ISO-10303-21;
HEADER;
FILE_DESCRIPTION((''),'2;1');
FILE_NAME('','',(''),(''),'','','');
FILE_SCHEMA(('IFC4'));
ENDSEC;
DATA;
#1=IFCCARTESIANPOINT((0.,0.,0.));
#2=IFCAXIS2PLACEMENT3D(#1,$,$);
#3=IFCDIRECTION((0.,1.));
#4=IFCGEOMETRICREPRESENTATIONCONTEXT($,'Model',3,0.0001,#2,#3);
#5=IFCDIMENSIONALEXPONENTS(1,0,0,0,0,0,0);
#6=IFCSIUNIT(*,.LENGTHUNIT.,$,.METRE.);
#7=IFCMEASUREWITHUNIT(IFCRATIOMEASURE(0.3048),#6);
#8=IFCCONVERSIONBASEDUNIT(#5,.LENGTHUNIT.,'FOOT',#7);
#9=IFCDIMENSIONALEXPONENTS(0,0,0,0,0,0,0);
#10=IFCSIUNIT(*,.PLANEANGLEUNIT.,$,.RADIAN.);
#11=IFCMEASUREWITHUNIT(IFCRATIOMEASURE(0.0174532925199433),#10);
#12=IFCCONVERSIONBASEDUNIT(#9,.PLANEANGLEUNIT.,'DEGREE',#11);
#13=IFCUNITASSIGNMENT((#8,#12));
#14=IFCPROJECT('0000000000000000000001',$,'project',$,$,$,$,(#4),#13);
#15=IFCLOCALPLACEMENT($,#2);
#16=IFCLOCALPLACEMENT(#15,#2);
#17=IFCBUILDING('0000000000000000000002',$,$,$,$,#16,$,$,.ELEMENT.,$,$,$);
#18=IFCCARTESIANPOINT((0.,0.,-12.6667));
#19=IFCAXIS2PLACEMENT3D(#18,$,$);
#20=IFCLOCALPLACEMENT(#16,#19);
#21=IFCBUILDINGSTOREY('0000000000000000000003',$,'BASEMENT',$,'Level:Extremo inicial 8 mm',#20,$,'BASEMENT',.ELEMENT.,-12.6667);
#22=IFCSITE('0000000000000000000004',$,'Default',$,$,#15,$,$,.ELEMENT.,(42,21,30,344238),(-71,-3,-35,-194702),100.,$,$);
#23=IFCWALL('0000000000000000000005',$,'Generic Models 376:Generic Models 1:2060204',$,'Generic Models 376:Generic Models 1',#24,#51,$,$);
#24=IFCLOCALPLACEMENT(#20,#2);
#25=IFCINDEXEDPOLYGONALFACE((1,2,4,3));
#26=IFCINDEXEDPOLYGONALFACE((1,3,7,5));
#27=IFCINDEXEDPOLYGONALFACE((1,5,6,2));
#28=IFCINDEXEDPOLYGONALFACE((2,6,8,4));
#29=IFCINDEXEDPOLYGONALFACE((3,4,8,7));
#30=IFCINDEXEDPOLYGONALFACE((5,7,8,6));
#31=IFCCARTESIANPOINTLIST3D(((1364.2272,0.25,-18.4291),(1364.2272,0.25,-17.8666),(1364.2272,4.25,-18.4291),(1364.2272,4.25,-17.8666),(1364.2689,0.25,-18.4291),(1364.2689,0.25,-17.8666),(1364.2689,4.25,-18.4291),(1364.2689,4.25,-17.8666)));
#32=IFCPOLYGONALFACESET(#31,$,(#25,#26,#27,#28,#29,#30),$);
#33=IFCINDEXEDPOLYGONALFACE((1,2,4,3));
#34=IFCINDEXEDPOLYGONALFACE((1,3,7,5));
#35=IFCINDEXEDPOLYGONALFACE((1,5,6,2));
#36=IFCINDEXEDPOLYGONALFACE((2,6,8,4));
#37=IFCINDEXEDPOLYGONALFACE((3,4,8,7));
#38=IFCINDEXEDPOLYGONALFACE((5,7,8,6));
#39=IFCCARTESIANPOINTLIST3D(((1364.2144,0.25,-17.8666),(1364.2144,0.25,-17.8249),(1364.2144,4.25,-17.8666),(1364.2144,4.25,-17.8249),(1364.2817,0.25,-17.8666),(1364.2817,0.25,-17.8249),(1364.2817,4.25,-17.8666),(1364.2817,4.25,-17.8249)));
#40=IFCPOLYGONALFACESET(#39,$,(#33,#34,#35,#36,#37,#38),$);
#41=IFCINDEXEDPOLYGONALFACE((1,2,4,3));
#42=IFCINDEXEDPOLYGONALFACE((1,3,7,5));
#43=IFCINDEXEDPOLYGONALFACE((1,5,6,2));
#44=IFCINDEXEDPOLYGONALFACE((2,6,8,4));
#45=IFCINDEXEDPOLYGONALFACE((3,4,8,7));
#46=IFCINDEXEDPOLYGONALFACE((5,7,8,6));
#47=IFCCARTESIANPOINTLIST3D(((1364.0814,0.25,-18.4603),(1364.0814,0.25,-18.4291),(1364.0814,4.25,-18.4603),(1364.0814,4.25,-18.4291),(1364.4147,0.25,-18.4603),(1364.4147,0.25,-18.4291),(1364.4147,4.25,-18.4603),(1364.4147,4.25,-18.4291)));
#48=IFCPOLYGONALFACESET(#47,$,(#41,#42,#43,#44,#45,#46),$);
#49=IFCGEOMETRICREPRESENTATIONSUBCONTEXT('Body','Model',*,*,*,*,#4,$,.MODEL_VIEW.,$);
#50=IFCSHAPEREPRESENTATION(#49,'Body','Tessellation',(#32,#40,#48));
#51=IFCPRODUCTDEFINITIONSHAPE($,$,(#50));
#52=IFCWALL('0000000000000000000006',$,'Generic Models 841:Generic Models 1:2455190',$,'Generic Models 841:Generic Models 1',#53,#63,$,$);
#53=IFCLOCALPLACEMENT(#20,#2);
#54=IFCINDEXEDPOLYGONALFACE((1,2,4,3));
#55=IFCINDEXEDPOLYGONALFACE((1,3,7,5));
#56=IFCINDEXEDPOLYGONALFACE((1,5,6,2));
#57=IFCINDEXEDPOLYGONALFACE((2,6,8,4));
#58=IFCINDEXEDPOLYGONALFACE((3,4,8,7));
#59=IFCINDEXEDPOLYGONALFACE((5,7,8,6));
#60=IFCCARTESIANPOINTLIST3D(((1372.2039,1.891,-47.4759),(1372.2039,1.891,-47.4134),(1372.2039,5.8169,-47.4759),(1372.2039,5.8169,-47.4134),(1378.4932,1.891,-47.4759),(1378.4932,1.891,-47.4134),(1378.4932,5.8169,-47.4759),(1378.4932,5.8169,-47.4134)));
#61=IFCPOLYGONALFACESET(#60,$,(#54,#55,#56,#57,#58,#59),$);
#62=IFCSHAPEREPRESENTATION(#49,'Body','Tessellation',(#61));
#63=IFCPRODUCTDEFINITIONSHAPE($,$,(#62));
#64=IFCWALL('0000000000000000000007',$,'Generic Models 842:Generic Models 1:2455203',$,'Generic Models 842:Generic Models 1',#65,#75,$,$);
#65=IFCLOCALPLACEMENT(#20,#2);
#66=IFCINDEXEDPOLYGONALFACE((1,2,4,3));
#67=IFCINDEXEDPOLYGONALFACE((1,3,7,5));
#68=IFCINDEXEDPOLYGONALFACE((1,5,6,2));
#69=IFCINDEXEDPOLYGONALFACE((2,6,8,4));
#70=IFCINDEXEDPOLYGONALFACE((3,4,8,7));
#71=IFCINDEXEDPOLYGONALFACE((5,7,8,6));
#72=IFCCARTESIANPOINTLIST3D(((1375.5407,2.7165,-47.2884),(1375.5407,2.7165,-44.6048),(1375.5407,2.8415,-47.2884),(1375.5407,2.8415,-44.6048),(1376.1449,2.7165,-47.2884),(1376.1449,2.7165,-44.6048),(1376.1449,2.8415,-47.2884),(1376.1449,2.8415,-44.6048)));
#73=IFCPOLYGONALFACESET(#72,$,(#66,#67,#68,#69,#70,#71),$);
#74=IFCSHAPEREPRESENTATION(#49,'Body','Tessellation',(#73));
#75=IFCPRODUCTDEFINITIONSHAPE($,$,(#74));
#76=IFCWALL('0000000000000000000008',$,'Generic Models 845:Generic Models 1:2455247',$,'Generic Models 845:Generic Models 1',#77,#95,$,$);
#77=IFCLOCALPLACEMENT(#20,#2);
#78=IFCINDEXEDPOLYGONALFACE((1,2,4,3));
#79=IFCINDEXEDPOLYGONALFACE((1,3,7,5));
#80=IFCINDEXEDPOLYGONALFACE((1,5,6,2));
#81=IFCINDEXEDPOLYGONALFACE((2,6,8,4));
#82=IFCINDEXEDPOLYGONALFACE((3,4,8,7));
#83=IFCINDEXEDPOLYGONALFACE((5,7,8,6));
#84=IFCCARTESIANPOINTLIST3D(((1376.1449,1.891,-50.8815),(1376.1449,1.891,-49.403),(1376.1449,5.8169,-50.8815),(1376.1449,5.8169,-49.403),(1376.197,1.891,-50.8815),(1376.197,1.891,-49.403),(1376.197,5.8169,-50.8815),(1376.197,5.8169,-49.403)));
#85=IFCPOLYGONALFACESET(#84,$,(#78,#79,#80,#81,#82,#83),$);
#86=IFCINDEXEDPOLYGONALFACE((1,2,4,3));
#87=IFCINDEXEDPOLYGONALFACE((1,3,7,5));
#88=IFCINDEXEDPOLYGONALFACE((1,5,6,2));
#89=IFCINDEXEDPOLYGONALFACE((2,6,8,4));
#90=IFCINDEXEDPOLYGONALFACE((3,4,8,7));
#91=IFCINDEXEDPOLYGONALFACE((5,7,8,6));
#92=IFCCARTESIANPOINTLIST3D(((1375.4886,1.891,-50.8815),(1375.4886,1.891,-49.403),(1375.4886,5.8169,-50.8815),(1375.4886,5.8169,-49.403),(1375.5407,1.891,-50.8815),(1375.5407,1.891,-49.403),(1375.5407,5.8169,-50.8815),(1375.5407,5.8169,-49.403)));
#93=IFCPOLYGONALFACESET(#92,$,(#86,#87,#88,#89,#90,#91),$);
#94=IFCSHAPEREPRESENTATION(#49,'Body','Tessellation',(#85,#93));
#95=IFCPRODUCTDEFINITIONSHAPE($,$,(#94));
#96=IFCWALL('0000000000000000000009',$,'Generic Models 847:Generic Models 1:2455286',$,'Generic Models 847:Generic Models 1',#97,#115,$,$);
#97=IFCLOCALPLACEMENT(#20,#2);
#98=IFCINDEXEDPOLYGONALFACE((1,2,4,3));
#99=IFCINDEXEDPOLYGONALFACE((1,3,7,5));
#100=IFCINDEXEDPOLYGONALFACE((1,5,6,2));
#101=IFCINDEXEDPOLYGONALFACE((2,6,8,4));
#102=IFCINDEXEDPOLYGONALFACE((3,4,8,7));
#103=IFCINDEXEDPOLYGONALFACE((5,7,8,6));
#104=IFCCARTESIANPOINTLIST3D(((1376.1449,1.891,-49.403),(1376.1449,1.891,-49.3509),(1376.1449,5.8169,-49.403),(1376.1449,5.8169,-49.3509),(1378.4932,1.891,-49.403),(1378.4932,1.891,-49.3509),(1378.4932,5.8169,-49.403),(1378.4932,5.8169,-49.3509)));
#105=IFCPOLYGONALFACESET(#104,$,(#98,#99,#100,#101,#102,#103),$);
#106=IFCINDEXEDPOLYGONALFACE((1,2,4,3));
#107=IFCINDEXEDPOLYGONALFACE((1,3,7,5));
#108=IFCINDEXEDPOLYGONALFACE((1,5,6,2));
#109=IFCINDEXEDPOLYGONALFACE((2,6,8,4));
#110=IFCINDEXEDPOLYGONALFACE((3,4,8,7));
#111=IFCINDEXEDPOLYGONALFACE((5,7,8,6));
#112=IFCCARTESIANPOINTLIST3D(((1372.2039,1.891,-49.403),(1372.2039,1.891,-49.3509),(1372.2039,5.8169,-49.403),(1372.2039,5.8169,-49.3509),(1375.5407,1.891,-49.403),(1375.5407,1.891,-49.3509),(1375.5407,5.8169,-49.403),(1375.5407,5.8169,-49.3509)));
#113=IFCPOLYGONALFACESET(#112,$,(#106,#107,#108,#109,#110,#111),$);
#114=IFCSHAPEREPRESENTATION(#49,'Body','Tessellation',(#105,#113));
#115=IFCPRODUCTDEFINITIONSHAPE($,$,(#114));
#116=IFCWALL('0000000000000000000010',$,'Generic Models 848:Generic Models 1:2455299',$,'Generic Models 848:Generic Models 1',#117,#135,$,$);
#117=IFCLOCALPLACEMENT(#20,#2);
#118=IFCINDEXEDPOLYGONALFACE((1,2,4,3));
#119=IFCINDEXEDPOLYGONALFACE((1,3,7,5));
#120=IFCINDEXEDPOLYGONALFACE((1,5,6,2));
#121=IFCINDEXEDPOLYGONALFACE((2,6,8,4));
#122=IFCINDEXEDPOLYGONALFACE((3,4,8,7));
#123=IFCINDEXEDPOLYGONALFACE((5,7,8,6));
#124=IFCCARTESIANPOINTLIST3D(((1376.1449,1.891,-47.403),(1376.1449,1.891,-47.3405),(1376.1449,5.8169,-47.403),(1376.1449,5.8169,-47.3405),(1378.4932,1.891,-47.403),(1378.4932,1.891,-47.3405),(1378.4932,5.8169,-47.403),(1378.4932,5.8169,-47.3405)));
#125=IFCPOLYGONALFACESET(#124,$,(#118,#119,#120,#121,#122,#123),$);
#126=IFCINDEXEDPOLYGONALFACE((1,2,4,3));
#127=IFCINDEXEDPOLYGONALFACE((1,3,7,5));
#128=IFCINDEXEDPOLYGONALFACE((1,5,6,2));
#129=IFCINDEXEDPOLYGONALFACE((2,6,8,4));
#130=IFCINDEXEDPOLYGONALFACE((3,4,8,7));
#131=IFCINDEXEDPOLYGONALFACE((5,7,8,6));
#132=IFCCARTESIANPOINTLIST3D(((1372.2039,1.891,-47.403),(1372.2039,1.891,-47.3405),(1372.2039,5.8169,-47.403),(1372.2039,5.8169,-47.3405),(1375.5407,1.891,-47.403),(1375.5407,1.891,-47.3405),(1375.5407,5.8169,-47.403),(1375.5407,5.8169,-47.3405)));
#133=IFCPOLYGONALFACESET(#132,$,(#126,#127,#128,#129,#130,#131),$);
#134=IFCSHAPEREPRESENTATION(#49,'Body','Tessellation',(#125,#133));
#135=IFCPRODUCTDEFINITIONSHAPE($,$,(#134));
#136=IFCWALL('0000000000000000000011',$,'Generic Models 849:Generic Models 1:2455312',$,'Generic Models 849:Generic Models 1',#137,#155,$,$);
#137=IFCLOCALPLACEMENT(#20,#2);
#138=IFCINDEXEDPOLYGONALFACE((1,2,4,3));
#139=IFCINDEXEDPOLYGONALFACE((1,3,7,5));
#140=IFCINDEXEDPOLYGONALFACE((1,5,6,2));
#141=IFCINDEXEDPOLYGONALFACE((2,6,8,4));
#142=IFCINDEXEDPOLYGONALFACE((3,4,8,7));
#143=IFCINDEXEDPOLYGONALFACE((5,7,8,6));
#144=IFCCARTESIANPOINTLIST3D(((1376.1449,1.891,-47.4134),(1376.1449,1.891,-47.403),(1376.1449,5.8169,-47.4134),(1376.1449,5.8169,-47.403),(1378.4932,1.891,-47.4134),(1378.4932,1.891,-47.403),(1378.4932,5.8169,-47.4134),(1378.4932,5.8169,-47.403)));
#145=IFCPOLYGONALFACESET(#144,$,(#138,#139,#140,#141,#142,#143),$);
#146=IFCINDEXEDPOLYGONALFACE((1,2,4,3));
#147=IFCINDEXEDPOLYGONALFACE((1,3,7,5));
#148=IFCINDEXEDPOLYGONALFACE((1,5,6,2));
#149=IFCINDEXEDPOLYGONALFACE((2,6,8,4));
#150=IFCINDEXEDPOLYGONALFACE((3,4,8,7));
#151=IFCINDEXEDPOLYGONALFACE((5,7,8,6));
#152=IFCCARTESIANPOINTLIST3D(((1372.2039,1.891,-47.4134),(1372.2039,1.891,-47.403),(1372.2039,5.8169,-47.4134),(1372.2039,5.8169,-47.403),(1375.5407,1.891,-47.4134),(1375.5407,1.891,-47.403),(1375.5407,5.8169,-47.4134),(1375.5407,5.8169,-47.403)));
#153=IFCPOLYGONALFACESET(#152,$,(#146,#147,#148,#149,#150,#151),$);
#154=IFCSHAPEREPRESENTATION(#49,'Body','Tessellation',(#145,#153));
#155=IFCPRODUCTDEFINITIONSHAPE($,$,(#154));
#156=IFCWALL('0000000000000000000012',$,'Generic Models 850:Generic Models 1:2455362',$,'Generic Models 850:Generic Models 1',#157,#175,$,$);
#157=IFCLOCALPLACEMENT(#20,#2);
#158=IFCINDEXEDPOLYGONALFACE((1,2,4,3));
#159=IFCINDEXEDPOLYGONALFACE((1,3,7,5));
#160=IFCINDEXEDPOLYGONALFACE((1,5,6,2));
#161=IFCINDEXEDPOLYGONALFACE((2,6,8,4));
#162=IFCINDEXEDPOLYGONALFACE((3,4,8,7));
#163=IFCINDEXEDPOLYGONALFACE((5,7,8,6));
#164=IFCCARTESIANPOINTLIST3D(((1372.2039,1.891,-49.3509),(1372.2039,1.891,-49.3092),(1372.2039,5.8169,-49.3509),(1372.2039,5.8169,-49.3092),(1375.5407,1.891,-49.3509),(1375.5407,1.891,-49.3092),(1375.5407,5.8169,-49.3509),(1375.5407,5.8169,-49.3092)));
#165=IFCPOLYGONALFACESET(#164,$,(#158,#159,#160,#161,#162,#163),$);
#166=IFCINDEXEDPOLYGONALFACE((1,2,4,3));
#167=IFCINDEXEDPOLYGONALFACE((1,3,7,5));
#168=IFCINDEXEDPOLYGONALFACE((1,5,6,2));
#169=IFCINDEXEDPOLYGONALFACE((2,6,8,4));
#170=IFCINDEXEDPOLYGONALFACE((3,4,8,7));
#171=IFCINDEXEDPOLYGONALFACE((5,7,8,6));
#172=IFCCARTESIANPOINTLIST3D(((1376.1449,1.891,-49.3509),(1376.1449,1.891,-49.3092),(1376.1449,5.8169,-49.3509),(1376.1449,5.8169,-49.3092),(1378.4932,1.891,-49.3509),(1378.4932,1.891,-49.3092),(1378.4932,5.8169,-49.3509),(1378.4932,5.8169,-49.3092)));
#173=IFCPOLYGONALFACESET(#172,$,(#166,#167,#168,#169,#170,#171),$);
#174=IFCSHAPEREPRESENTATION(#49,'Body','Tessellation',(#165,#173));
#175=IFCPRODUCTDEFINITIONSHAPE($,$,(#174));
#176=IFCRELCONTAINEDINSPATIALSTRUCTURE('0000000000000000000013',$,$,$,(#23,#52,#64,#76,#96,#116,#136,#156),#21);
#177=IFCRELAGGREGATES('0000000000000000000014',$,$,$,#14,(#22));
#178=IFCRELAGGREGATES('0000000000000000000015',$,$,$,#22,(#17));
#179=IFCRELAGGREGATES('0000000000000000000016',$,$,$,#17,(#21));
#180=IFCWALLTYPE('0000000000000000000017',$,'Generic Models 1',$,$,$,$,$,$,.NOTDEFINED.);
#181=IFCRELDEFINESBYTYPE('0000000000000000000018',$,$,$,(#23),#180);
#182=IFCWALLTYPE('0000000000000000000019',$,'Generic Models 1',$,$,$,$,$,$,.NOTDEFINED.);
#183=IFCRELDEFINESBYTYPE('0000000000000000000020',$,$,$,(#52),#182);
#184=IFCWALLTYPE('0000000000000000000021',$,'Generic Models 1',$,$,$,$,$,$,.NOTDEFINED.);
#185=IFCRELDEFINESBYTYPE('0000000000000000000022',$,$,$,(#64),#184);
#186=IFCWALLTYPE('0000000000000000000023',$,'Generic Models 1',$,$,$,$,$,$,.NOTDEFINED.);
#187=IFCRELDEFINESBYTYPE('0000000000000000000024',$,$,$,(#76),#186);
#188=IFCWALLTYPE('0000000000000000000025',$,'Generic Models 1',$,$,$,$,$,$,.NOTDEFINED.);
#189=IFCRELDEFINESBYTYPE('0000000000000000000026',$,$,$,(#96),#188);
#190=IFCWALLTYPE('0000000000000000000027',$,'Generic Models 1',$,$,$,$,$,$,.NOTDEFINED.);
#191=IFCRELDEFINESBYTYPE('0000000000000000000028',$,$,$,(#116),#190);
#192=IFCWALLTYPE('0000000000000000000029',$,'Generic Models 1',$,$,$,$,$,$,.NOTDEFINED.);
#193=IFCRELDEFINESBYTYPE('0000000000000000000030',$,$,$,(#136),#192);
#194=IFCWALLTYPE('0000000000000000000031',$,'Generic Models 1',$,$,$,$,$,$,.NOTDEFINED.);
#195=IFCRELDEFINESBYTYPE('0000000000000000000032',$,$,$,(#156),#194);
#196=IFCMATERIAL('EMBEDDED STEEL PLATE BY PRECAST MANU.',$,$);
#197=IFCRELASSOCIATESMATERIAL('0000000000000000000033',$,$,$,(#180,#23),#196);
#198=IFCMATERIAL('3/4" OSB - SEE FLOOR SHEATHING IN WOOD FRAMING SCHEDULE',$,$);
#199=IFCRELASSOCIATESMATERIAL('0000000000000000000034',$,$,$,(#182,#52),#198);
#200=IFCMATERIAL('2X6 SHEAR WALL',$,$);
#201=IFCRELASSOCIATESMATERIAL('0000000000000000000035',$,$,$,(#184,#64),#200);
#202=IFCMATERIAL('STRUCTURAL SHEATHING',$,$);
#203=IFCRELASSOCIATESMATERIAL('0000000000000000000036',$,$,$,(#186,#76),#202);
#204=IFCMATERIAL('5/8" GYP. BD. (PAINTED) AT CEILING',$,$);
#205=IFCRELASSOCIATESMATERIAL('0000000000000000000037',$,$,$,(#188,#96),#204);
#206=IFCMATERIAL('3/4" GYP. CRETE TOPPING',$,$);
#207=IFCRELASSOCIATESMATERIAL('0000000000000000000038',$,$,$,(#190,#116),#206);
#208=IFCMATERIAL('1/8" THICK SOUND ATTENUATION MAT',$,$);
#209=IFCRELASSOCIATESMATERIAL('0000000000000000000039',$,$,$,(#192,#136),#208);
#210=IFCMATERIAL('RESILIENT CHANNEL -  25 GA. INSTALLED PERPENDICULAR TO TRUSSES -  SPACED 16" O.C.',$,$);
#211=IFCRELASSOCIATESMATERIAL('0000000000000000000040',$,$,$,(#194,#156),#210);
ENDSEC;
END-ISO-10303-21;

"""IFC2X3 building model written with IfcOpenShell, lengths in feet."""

from ifc_helpers import new_model, entity, si_unit, converted_unit, direction, frame, frame_2d, origin, origin_2d_with_axis, place, context, subcontext, project, spatial, rectangle, extrude, material, type_object, element, save


model = new_model("IFC2X3")

# Units and contexts
model_context = context("Model", 3, precision=0.0001, world=origin(), true_north=direction((0.0, 1.0)))
body_context = subcontext(model_context, "Body", "Model", "MODEL_VIEW")
ifc_project = project(units=[converted_unit("LENGTHUNIT", "FOOT", entity("IfcRatioMeasure", 0.3048), si_unit("LENGTHUNIT", "METRE"), dimensions=[1, 0, 0, 0, 0, 0, 0]), converted_unit("PLANEANGLEUNIT", "DEGREE", entity("IfcRatioMeasure", 0.0174532925199433), si_unit("PLANEANGLEUNIT", "RADIAN"), dimensions=[0, 0, 0, 0, 0, 0, 0])], contexts=[model_context])

# Site, building, storey
site_placement = place(None, origin())
site = spatial("IfcSite", under=ifc_project, at=site_placement, Name="Default", CompositionType="ELEMENT", RefLatitude=(42, 21, 30, 344238), RefLongitude=(-71, -3, -35, -194702), RefElevation=100.0)
building_placement = place(site_placement, origin())
building = spatial("IfcBuilding", under=site, at=building_placement, CompositionType="ELEMENT")
storey_placement = place(building_placement, frame((0.0, 0.0, -12.6667)))
storey = spatial("IfcBuildingStorey", under=building, at=storey_placement, Name="BASEMENT", ObjectType="Level:Extremo inicial 8 mm", LongName="BASEMENT", CompositionType="ELEMENT", Elevation=-12.6667)

# Walls
ifc_material_1 = material(Name="EMBEDDED STEEL PLATE BY PRECAST MANU.")
wall_type_1 = type_object("IfcWallType", Name="Generic Models 1", PredefinedType="NOTDEFINED", material=ifc_material_1)
wall_1_placement = place(storey_placement, frame((1364.0814, 0.25, -18.4603), z_axis=(0.0, 0.0, 1.0), x_axis=(0.0, 1.0, 0.0)))
element("IfcWall", 1, at=wall_1_placement, inside=storey, type_object=wall_type_1, material=ifc_material_1, Name="Generic Models 376:Generic Models 1:2060204", ObjectType="Generic Models 376:Generic Models 1", context=body_context, shape_type="SweptSolid", body=[
    extrude(rectangle(XDim=4.0, YDim=0.0417, at=frame_2d((0.0, 0.0), x_axis=(1.0, 0.0))), frame((2.0, -0.1667, 0.0312)), (0.0, 0.0, 1.0), 0.5625),
    extrude(rectangle(XDim=4.0, YDim=0.0673, at=origin_2d_with_axis()), frame((2.0, -0.1667, 0.5937)), (0.0, 0.0, 1.0), 0.0417),
    extrude(rectangle(XDim=4.0, YDim=0.3333, at=frame_2d((0.0, 0.0), x_axis=(1.0, 0.0))), frame((2.0, -0.1667, 0.0)), (0.0, 0.0, 1.0), 0.0312),
])
ifc_material_2 = material(Name="3/4\" OSB - SEE FLOOR SHEATHING IN WOOD FRAMING SCHEDULE")
wall_type_2 = type_object("IfcWallType", Name="Generic Models 1", PredefinedType="NOTDEFINED", material=ifc_material_2)
wall_2_placement = place(storey_placement, frame((1372.2039, 1.891, -47.4759)))
element("IfcWall", 2, at=wall_2_placement, inside=storey, type_object=wall_type_2, material=ifc_material_2, Name="Generic Models 841:Generic Models 1:2455190", ObjectType="Generic Models 841:Generic Models 1", context=body_context, shape_type="SweptSolid", body=[
    extrude(rectangle(XDim=3.9258, YDim=6.2893, at=origin_2d_with_axis()), frame((3.1446, 1.9629, 0.0), z_axis=(0.0, 0.0, 1.0), x_axis=(0.0, 1.0, 0.0)), (0.0, 0.0, 1.0), 0.0625),
])
ifc_material_3 = material(Name="2X6 SHEAR WALL")
wall_type_3 = type_object("IfcWallType", Name="Generic Models 1", PredefinedType="NOTDEFINED", material=ifc_material_3)
wall_3_placement = place(storey_placement, frame((1375.5407, 2.7165, -47.2884)))
element("IfcWall", 3, at=wall_3_placement, inside=storey, type_object=wall_type_3, material=ifc_material_3, Name="Generic Models 842:Generic Models 1:2455203", ObjectType="Generic Models 842:Generic Models 1", context=body_context, shape_type="SweptSolid", body=[
    extrude(rectangle(XDim=0.125, YDim=0.6042, at=frame_2d((0.0, 0.0), x_axis=(1.0, 0.0))), frame((0.3021, 0.0625, 0.0), z_axis=(0.0, 0.0, 1.0), x_axis=(0.0, 1.0, 0.0)), (0.0, 0.0, 1.0), 2.6836),
])
ifc_material_4 = material(Name="STRUCTURAL SHEATHING")
wall_type_4 = type_object("IfcWallType", Name="Generic Models 1", PredefinedType="NOTDEFINED", material=ifc_material_4)
wall_4_placement = place(storey_placement, frame((1375.4886, 1.891, -50.8815), z_axis=(0.0, 0.0, 1.0), x_axis=(0.0, 1.0, 0.0)))
element("IfcWall", 4, at=wall_4_placement, inside=storey, type_object=wall_type_4, material=ifc_material_4, Name="Generic Models 845:Generic Models 1:2455247", ObjectType="Generic Models 845:Generic Models 1", context=body_context, shape_type="SweptSolid", body=[
    extrude(rectangle(XDim=3.9258, YDim=0.0521, at=frame_2d((0.0, 0.0), x_axis=(1.0, 0.0))), frame((1.9629, -0.6823, 0.0)), (0.0, 0.0, 1.0), 1.4786),
    extrude(rectangle(XDim=3.9258, YDim=0.0521, at=frame_2d((0.0, 0.0), x_axis=(1.0, 0.0))), frame((1.9629, -0.026, 0.0)), (0.0, 0.0, 1.0), 1.4786),
])
ifc_material_5 = material(Name="5/8\" GYP. BD. (PAINTED) AT CEILING")
wall_type_5 = type_object("IfcWallType", Name="Generic Models 1", PredefinedType="NOTDEFINED", material=ifc_material_5)
wall_5_placement = place(storey_placement, frame((1372.2039, 1.891, -49.403)))
element("IfcWall", 5, at=wall_5_placement, inside=storey, type_object=wall_type_5, material=ifc_material_5, Name="Generic Models 847:Generic Models 1:2455286", ObjectType="Generic Models 847:Generic Models 1", context=body_context, shape_type="SweptSolid", body=[
    extrude(rectangle(XDim=3.9258, YDim=2.3483, at=frame_2d((0.0, 0.0), x_axis=(1.0, 0.0))), frame((5.1152, 1.9629, 0.0), z_axis=(0.0, 0.0, 1.0), x_axis=(0.0, 1.0, 0.0)), (0.0, 0.0, 1.0), 0.0521),
    extrude(rectangle(XDim=3.9258, YDim=3.3369, at=frame_2d((0.0, 0.0), x_axis=(1.0, 0.0))), frame((1.6684, 1.9629, 0.0), z_axis=(0.0, 0.0, 1.0), x_axis=(0.0, 1.0, 0.0)), (0.0, 0.0, 1.0), 0.0521),
])
ifc_material_6 = material(Name="3/4\" GYP. CRETE TOPPING")
wall_type_6 = type_object("IfcWallType", Name="Generic Models 1", PredefinedType="NOTDEFINED", material=ifc_material_6)
wall_6_placement = place(storey_placement, frame((1372.2039, 1.891, -47.403)))
element("IfcWall", 6, at=wall_6_placement, inside=storey, type_object=wall_type_6, material=ifc_material_6, Name="Generic Models 848:Generic Models 1:2455299", ObjectType="Generic Models 848:Generic Models 1", context=body_context, shape_type="SweptSolid", body=[
    extrude(rectangle(XDim=3.9258, YDim=2.3483, at=frame_2d((0.0, 0.0), x_axis=(1.0, 0.0))), frame((5.1152, 1.9629, 0.0), z_axis=(0.0, 0.0, 1.0), x_axis=(0.0, 1.0, 0.0)), (0.0, 0.0, 1.0), 0.0625),
    extrude(rectangle(XDim=3.9258, YDim=3.3369, at=origin_2d_with_axis()), frame((1.6684, 1.9629, 0.0), z_axis=(0.0, 0.0, 1.0), x_axis=(0.0, 1.0, 0.0)), (0.0, 0.0, 1.0), 0.0625),
])
ifc_material_7 = material(Name="1/8\" THICK SOUND ATTENUATION MAT")
wall_type_7 = type_object("IfcWallType", Name="Generic Models 1", PredefinedType="NOTDEFINED", material=ifc_material_7)
wall_7_placement = place(storey_placement, frame((1372.2039, 1.891, -47.4134)))
element("IfcWall", 7, at=wall_7_placement, inside=storey, type_object=wall_type_7, material=ifc_material_7, Name="Generic Models 849:Generic Models 1:2455312", ObjectType="Generic Models 849:Generic Models 1", context=body_context, shape_type="SweptSolid", body=[
    extrude(rectangle(XDim=3.9258, YDim=2.3483, at=frame_2d((0.0, 0.0), x_axis=(1.0, 0.0))), frame((5.1152, 1.9629, 0.0), z_axis=(0.0, 0.0, 1.0), x_axis=(0.0, 1.0, 0.0)), (0.0, 0.0, 1.0), 0.0104),
    extrude(rectangle(XDim=3.9258, YDim=3.3369, at=origin_2d_with_axis()), frame((1.6684, 1.9629, 0.0), z_axis=(0.0, 0.0, 1.0), x_axis=(0.0, 1.0, 0.0)), (0.0, 0.0, 1.0), 0.0104),
])
ifc_material_8 = material(Name="RESILIENT CHANNEL -  25 GA. INSTALLED PERPENDICULAR TO TRUSSES -  SPACED 16\" O.C.")
wall_type_8 = type_object("IfcWallType", Name="Generic Models 1", PredefinedType="NOTDEFINED", material=ifc_material_8)
wall_8_placement = place(storey_placement, frame((1372.2039, 1.891, -49.3509)))
element("IfcWall", 8, at=wall_8_placement, inside=storey, type_object=wall_type_8, material=ifc_material_8, Name="Generic Models 850:Generic Models 1:2455362", ObjectType="Generic Models 850:Generic Models 1", context=body_context, shape_type="SweptSolid", body=[
    extrude(rectangle(XDim=3.9258, YDim=3.3369, at=frame_2d((0.0, 0.0), x_axis=(1.0, 0.0))), frame((1.6684, 1.9629, 0.0), z_axis=(0.0, 0.0, 1.0), x_axis=(0.0, 1.0, 0.0)), (0.0, 0.0, 1.0), 0.0417),
    extrude(rectangle(XDim=3.9258, YDim=2.3483, at=frame_2d((0.0, 0.0), x_axis=(1.0, 0.0))), frame((5.1152, 1.9629, 0.0), z_axis=(0.0, 0.0, 1.0), x_axis=(0.0, 1.0, 0.0)), (0.0, 0.0, 1.0), 0.0417),
])

save(model, "model.ifc")
